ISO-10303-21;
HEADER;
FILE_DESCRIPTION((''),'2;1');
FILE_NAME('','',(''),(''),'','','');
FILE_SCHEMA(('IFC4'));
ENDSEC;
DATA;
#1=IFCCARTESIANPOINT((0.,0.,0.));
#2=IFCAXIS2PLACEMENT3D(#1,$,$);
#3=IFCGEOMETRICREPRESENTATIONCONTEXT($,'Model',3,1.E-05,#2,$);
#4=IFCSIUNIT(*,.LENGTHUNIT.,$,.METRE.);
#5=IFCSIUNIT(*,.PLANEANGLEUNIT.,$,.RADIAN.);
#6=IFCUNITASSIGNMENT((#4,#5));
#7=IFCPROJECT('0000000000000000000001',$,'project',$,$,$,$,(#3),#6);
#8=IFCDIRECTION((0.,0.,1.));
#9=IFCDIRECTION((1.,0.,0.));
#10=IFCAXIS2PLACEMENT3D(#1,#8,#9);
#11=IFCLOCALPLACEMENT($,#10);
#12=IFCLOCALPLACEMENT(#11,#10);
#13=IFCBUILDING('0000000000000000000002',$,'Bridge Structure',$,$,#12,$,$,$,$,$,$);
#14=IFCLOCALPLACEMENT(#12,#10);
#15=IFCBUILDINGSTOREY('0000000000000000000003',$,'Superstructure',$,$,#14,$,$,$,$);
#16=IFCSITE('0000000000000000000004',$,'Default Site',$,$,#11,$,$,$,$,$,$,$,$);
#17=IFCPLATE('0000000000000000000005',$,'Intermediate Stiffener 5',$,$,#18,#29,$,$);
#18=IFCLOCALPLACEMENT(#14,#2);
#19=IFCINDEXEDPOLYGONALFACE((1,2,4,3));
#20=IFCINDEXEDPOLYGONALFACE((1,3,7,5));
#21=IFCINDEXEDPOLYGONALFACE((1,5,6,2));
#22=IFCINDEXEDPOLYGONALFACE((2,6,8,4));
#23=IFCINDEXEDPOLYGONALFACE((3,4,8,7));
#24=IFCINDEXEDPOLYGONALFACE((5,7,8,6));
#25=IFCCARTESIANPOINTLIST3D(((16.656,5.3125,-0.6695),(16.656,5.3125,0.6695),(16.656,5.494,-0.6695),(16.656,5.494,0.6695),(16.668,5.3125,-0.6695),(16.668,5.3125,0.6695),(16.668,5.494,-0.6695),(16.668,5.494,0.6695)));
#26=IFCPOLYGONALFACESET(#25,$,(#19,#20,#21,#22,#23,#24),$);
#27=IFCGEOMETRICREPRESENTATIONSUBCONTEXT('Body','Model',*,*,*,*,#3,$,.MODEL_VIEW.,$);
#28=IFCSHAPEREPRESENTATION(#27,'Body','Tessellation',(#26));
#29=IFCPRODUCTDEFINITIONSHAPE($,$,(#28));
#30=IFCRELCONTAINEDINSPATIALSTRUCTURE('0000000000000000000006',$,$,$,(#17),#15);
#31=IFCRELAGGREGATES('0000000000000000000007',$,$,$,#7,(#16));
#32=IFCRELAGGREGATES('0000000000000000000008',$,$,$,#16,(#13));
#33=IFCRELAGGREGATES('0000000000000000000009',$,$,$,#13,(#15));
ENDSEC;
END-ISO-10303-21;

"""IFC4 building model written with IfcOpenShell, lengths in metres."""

from ifc_helpers import new_model, si_unit, frame, origin, origin_with_axes, origin_2d_with_axis, place, context, subcontext, project, spatial, rectangle, extrude, element, save


model = new_model("IFC4")

# Units and contexts
model_context = context("Model", 3, precision=1e-05, world=origin())
body_context = subcontext(model_context, "Body", "Model", "MODEL_VIEW")
ifc_project = project(units=[si_unit("LENGTHUNIT", "METRE"), si_unit("PLANEANGLEUNIT", "RADIAN")], contexts=[model_context])

# Site, building, storey
site_placement = place(None, origin_with_axes())
site = spatial("IfcSite", under=ifc_project, at=site_placement, Name="Default Site")
building_placement = place(site_placement, origin_with_axes())
building = spatial("IfcBuilding", under=site, at=building_placement, Name="Bridge Structure")
storey_placement = place(building_placement, origin_with_axes())
storey = spatial("IfcBuildingStorey", under=building, at=storey_placement, Name="Superstructure")

# Plate
for number, where, z_axis, x_axis, name in (
    (1, (16.662, 5.4032, -0.6695), (0.0, 0.0, 1.0), (1.0, 0.0, 0.0), "Intermediate Stiffener 5"),
):
    element("IfcPlate", number, at=place(storey_placement, frame(where, z_axis=z_axis, x_axis=x_axis)), inside=storey, Name=name, context=body_context, shape_type="SweptSolid", body=[
        extrude(rectangle(XDim=0.012, YDim=0.1815, at=origin_2d_with_axis()), origin_with_axes(), (0.0, 0.0, 1.0), 1.339),
    ])

save(model, "model.ifc")
